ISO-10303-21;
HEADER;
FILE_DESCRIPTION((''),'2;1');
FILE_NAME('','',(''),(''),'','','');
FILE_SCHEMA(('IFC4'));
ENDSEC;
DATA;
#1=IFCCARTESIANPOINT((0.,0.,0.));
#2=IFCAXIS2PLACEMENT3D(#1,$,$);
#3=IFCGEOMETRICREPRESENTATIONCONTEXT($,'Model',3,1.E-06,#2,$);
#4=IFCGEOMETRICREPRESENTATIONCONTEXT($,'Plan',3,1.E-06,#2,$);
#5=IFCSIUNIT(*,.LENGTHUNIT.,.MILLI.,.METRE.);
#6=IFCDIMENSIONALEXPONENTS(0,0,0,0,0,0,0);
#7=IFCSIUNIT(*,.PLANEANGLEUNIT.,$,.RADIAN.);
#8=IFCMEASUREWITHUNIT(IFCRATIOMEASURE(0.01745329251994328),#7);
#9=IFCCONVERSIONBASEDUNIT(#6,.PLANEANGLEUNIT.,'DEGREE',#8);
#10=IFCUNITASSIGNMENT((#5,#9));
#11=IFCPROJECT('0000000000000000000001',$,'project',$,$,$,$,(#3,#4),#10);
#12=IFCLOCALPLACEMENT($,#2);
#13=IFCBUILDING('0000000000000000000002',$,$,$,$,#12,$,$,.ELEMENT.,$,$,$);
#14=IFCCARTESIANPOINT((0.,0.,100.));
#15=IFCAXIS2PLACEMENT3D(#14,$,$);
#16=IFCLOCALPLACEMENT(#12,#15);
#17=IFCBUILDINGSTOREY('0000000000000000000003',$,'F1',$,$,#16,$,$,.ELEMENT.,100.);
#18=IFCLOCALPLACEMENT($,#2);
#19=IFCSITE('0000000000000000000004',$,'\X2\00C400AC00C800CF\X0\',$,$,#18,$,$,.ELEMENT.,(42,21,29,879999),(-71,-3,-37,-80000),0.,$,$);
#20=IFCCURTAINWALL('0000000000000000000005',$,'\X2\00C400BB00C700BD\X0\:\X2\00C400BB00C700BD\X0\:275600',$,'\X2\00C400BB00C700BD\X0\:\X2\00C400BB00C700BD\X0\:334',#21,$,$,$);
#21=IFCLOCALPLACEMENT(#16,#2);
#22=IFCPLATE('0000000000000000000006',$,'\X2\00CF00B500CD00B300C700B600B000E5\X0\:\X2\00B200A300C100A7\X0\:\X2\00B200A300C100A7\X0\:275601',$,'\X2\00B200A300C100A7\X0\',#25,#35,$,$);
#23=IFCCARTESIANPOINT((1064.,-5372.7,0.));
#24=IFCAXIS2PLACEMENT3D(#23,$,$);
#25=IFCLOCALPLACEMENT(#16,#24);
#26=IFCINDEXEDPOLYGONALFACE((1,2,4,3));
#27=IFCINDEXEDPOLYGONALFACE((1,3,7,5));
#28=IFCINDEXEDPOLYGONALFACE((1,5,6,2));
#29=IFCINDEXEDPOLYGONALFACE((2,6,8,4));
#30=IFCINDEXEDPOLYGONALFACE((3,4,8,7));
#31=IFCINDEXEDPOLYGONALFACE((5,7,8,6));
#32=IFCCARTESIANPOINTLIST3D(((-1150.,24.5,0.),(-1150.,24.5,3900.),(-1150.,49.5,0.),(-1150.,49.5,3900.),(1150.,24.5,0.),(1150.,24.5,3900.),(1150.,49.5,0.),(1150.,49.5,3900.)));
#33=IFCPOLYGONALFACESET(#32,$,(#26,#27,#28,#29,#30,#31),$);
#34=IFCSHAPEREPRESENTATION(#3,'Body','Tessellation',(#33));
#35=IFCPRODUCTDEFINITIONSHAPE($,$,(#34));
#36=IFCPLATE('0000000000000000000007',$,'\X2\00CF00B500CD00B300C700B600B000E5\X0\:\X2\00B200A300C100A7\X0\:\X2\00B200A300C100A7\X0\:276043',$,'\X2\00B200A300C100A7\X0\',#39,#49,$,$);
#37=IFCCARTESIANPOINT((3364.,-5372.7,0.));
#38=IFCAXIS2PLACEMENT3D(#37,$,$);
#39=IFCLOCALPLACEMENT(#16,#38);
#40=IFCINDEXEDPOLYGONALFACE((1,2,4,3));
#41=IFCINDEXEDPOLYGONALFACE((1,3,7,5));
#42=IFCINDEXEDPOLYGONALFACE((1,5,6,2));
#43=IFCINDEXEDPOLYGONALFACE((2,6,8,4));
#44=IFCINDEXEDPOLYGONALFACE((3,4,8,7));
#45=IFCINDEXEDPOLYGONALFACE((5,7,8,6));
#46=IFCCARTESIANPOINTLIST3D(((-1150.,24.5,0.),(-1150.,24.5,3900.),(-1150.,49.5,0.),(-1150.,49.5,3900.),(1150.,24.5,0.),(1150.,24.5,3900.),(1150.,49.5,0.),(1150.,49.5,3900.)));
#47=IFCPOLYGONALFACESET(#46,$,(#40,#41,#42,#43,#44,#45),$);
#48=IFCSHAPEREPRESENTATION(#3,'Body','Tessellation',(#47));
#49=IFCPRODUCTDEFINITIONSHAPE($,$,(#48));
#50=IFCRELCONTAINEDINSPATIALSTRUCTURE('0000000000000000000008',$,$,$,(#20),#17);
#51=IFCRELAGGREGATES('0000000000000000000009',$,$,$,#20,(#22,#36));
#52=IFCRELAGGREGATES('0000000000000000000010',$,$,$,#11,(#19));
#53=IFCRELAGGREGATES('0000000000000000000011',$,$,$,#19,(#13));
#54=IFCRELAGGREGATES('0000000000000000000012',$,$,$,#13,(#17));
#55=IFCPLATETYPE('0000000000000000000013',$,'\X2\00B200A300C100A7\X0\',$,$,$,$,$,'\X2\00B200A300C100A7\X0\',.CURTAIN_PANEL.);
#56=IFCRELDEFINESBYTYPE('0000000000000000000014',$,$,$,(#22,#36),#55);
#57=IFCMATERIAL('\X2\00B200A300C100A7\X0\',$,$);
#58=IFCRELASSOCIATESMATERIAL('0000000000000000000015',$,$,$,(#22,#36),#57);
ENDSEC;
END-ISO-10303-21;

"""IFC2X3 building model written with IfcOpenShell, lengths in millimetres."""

from ifc_helpers import new_model, entity, si_unit, converted_unit, frame, origin, origin_2d_with_axis, place, context, project, spatial, rectangle, extrude, source, transform, mapped, material, type_object, type_shapes, element, aggregate, save


model = new_model("IFC2X3")

# Units and contexts
model_context = context("Model", 3, precision=1e-06, world=origin())
plan_context = context("Plan", 3, precision=1e-06, world=origin())
ifc_project = project(units=[si_unit("LENGTHUNIT", "METRE", prefix="MILLI"), converted_unit("PLANEANGLEUNIT", "DEGREE", entity("IfcRatioMeasure", 0.01745329251994328), si_unit("PLANEANGLEUNIT", "RADIAN"), dimensions=[0, 0, 0, 0, 0, 0, 0])], contexts=[model_context, plan_context])

# Site, building, storey
site_placement = place(None, origin())
site = spatial("IfcSite", under=ifc_project, at=site_placement, Name="Ä¬ÈÏ", CompositionType="ELEMENT", RefLatitude=(42, 21, 29, 879999), RefLongitude=(-71, -3, -37, -80000), RefElevation=0.0)
building_placement = place(None, origin())
building = spatial("IfcBuilding", under=site, at=building_placement, CompositionType="ELEMENT")
storey_placement = place(building_placement, frame((0.0, 0.0, 100.0)))
storey = spatial("IfcBuildingStorey", under=building, at=storey_placement, Name="F1", CompositionType="ELEMENT", Elevation=100.0)

# Curtain wall
curtain_wall_placement = place(storey_placement, origin())
curtain_wall = element("IfcCurtainWall", 1, at=curtain_wall_placement, inside=storey, Name="Ä»Ç½:Ä»Ç½:275600", ObjectType="Ä»Ç½:Ä»Ç½:334")

# Plates
ifc_material_1 = material(Name="²£Á§")
plate_type = type_object("IfcPlateType", Name="²£Á§", ElementType="²£Á§", PredefinedType="CURTAIN_PANEL")
shared_shape_1 = source(origin(), model_context, "Body", "SweptSolid", [
    extrude(rectangle(XDim=25.0, YDim=2300.0, at=origin_2d_with_axis()), frame((0.0, 37.0, 0.0), z_axis=(0.0, 0.0, 1.0), x_axis=(0.0, 1.0, 0.0)), (0.0, 0.0, 1.0), 3900.0),
])
type_shapes(plate_type, [shared_shape_1])
plate_1_placement = place(storey_placement, frame((1064.0, -5372.7, 0.0)))
plate_1 = element("IfcPlate", 2, at=plate_1_placement, type_object=plate_type, material=ifc_material_1, Name="ÏµÍ³Ç¶°å:²£Á§:²£Á§:275601", ObjectType="²£Á§", context=model_context, shape_type="MappedRepresentation", body=[
    mapped(shared_shape_1, transform((0.0, 0.0, 0.0), scale=1.0)),
])
plate_2_placement = place(storey_placement, frame((3364.0, -5372.7, 0.0)))
plate_2 = element("IfcPlate", 3, at=plate_2_placement, type_object=plate_type, material=ifc_material_1, Name="ÏµÍ³Ç¶°å:²£Á§:²£Á§:276043", ObjectType="²£Á§", context=model_context, shape_type="MappedRepresentation", body=[
    mapped(shared_shape_1, transform((0.0, 0.0, 0.0), scale=1.0)),
])
aggregate(curtain_wall, [plate_1, plate_2])

save(model, "model.ifc")
